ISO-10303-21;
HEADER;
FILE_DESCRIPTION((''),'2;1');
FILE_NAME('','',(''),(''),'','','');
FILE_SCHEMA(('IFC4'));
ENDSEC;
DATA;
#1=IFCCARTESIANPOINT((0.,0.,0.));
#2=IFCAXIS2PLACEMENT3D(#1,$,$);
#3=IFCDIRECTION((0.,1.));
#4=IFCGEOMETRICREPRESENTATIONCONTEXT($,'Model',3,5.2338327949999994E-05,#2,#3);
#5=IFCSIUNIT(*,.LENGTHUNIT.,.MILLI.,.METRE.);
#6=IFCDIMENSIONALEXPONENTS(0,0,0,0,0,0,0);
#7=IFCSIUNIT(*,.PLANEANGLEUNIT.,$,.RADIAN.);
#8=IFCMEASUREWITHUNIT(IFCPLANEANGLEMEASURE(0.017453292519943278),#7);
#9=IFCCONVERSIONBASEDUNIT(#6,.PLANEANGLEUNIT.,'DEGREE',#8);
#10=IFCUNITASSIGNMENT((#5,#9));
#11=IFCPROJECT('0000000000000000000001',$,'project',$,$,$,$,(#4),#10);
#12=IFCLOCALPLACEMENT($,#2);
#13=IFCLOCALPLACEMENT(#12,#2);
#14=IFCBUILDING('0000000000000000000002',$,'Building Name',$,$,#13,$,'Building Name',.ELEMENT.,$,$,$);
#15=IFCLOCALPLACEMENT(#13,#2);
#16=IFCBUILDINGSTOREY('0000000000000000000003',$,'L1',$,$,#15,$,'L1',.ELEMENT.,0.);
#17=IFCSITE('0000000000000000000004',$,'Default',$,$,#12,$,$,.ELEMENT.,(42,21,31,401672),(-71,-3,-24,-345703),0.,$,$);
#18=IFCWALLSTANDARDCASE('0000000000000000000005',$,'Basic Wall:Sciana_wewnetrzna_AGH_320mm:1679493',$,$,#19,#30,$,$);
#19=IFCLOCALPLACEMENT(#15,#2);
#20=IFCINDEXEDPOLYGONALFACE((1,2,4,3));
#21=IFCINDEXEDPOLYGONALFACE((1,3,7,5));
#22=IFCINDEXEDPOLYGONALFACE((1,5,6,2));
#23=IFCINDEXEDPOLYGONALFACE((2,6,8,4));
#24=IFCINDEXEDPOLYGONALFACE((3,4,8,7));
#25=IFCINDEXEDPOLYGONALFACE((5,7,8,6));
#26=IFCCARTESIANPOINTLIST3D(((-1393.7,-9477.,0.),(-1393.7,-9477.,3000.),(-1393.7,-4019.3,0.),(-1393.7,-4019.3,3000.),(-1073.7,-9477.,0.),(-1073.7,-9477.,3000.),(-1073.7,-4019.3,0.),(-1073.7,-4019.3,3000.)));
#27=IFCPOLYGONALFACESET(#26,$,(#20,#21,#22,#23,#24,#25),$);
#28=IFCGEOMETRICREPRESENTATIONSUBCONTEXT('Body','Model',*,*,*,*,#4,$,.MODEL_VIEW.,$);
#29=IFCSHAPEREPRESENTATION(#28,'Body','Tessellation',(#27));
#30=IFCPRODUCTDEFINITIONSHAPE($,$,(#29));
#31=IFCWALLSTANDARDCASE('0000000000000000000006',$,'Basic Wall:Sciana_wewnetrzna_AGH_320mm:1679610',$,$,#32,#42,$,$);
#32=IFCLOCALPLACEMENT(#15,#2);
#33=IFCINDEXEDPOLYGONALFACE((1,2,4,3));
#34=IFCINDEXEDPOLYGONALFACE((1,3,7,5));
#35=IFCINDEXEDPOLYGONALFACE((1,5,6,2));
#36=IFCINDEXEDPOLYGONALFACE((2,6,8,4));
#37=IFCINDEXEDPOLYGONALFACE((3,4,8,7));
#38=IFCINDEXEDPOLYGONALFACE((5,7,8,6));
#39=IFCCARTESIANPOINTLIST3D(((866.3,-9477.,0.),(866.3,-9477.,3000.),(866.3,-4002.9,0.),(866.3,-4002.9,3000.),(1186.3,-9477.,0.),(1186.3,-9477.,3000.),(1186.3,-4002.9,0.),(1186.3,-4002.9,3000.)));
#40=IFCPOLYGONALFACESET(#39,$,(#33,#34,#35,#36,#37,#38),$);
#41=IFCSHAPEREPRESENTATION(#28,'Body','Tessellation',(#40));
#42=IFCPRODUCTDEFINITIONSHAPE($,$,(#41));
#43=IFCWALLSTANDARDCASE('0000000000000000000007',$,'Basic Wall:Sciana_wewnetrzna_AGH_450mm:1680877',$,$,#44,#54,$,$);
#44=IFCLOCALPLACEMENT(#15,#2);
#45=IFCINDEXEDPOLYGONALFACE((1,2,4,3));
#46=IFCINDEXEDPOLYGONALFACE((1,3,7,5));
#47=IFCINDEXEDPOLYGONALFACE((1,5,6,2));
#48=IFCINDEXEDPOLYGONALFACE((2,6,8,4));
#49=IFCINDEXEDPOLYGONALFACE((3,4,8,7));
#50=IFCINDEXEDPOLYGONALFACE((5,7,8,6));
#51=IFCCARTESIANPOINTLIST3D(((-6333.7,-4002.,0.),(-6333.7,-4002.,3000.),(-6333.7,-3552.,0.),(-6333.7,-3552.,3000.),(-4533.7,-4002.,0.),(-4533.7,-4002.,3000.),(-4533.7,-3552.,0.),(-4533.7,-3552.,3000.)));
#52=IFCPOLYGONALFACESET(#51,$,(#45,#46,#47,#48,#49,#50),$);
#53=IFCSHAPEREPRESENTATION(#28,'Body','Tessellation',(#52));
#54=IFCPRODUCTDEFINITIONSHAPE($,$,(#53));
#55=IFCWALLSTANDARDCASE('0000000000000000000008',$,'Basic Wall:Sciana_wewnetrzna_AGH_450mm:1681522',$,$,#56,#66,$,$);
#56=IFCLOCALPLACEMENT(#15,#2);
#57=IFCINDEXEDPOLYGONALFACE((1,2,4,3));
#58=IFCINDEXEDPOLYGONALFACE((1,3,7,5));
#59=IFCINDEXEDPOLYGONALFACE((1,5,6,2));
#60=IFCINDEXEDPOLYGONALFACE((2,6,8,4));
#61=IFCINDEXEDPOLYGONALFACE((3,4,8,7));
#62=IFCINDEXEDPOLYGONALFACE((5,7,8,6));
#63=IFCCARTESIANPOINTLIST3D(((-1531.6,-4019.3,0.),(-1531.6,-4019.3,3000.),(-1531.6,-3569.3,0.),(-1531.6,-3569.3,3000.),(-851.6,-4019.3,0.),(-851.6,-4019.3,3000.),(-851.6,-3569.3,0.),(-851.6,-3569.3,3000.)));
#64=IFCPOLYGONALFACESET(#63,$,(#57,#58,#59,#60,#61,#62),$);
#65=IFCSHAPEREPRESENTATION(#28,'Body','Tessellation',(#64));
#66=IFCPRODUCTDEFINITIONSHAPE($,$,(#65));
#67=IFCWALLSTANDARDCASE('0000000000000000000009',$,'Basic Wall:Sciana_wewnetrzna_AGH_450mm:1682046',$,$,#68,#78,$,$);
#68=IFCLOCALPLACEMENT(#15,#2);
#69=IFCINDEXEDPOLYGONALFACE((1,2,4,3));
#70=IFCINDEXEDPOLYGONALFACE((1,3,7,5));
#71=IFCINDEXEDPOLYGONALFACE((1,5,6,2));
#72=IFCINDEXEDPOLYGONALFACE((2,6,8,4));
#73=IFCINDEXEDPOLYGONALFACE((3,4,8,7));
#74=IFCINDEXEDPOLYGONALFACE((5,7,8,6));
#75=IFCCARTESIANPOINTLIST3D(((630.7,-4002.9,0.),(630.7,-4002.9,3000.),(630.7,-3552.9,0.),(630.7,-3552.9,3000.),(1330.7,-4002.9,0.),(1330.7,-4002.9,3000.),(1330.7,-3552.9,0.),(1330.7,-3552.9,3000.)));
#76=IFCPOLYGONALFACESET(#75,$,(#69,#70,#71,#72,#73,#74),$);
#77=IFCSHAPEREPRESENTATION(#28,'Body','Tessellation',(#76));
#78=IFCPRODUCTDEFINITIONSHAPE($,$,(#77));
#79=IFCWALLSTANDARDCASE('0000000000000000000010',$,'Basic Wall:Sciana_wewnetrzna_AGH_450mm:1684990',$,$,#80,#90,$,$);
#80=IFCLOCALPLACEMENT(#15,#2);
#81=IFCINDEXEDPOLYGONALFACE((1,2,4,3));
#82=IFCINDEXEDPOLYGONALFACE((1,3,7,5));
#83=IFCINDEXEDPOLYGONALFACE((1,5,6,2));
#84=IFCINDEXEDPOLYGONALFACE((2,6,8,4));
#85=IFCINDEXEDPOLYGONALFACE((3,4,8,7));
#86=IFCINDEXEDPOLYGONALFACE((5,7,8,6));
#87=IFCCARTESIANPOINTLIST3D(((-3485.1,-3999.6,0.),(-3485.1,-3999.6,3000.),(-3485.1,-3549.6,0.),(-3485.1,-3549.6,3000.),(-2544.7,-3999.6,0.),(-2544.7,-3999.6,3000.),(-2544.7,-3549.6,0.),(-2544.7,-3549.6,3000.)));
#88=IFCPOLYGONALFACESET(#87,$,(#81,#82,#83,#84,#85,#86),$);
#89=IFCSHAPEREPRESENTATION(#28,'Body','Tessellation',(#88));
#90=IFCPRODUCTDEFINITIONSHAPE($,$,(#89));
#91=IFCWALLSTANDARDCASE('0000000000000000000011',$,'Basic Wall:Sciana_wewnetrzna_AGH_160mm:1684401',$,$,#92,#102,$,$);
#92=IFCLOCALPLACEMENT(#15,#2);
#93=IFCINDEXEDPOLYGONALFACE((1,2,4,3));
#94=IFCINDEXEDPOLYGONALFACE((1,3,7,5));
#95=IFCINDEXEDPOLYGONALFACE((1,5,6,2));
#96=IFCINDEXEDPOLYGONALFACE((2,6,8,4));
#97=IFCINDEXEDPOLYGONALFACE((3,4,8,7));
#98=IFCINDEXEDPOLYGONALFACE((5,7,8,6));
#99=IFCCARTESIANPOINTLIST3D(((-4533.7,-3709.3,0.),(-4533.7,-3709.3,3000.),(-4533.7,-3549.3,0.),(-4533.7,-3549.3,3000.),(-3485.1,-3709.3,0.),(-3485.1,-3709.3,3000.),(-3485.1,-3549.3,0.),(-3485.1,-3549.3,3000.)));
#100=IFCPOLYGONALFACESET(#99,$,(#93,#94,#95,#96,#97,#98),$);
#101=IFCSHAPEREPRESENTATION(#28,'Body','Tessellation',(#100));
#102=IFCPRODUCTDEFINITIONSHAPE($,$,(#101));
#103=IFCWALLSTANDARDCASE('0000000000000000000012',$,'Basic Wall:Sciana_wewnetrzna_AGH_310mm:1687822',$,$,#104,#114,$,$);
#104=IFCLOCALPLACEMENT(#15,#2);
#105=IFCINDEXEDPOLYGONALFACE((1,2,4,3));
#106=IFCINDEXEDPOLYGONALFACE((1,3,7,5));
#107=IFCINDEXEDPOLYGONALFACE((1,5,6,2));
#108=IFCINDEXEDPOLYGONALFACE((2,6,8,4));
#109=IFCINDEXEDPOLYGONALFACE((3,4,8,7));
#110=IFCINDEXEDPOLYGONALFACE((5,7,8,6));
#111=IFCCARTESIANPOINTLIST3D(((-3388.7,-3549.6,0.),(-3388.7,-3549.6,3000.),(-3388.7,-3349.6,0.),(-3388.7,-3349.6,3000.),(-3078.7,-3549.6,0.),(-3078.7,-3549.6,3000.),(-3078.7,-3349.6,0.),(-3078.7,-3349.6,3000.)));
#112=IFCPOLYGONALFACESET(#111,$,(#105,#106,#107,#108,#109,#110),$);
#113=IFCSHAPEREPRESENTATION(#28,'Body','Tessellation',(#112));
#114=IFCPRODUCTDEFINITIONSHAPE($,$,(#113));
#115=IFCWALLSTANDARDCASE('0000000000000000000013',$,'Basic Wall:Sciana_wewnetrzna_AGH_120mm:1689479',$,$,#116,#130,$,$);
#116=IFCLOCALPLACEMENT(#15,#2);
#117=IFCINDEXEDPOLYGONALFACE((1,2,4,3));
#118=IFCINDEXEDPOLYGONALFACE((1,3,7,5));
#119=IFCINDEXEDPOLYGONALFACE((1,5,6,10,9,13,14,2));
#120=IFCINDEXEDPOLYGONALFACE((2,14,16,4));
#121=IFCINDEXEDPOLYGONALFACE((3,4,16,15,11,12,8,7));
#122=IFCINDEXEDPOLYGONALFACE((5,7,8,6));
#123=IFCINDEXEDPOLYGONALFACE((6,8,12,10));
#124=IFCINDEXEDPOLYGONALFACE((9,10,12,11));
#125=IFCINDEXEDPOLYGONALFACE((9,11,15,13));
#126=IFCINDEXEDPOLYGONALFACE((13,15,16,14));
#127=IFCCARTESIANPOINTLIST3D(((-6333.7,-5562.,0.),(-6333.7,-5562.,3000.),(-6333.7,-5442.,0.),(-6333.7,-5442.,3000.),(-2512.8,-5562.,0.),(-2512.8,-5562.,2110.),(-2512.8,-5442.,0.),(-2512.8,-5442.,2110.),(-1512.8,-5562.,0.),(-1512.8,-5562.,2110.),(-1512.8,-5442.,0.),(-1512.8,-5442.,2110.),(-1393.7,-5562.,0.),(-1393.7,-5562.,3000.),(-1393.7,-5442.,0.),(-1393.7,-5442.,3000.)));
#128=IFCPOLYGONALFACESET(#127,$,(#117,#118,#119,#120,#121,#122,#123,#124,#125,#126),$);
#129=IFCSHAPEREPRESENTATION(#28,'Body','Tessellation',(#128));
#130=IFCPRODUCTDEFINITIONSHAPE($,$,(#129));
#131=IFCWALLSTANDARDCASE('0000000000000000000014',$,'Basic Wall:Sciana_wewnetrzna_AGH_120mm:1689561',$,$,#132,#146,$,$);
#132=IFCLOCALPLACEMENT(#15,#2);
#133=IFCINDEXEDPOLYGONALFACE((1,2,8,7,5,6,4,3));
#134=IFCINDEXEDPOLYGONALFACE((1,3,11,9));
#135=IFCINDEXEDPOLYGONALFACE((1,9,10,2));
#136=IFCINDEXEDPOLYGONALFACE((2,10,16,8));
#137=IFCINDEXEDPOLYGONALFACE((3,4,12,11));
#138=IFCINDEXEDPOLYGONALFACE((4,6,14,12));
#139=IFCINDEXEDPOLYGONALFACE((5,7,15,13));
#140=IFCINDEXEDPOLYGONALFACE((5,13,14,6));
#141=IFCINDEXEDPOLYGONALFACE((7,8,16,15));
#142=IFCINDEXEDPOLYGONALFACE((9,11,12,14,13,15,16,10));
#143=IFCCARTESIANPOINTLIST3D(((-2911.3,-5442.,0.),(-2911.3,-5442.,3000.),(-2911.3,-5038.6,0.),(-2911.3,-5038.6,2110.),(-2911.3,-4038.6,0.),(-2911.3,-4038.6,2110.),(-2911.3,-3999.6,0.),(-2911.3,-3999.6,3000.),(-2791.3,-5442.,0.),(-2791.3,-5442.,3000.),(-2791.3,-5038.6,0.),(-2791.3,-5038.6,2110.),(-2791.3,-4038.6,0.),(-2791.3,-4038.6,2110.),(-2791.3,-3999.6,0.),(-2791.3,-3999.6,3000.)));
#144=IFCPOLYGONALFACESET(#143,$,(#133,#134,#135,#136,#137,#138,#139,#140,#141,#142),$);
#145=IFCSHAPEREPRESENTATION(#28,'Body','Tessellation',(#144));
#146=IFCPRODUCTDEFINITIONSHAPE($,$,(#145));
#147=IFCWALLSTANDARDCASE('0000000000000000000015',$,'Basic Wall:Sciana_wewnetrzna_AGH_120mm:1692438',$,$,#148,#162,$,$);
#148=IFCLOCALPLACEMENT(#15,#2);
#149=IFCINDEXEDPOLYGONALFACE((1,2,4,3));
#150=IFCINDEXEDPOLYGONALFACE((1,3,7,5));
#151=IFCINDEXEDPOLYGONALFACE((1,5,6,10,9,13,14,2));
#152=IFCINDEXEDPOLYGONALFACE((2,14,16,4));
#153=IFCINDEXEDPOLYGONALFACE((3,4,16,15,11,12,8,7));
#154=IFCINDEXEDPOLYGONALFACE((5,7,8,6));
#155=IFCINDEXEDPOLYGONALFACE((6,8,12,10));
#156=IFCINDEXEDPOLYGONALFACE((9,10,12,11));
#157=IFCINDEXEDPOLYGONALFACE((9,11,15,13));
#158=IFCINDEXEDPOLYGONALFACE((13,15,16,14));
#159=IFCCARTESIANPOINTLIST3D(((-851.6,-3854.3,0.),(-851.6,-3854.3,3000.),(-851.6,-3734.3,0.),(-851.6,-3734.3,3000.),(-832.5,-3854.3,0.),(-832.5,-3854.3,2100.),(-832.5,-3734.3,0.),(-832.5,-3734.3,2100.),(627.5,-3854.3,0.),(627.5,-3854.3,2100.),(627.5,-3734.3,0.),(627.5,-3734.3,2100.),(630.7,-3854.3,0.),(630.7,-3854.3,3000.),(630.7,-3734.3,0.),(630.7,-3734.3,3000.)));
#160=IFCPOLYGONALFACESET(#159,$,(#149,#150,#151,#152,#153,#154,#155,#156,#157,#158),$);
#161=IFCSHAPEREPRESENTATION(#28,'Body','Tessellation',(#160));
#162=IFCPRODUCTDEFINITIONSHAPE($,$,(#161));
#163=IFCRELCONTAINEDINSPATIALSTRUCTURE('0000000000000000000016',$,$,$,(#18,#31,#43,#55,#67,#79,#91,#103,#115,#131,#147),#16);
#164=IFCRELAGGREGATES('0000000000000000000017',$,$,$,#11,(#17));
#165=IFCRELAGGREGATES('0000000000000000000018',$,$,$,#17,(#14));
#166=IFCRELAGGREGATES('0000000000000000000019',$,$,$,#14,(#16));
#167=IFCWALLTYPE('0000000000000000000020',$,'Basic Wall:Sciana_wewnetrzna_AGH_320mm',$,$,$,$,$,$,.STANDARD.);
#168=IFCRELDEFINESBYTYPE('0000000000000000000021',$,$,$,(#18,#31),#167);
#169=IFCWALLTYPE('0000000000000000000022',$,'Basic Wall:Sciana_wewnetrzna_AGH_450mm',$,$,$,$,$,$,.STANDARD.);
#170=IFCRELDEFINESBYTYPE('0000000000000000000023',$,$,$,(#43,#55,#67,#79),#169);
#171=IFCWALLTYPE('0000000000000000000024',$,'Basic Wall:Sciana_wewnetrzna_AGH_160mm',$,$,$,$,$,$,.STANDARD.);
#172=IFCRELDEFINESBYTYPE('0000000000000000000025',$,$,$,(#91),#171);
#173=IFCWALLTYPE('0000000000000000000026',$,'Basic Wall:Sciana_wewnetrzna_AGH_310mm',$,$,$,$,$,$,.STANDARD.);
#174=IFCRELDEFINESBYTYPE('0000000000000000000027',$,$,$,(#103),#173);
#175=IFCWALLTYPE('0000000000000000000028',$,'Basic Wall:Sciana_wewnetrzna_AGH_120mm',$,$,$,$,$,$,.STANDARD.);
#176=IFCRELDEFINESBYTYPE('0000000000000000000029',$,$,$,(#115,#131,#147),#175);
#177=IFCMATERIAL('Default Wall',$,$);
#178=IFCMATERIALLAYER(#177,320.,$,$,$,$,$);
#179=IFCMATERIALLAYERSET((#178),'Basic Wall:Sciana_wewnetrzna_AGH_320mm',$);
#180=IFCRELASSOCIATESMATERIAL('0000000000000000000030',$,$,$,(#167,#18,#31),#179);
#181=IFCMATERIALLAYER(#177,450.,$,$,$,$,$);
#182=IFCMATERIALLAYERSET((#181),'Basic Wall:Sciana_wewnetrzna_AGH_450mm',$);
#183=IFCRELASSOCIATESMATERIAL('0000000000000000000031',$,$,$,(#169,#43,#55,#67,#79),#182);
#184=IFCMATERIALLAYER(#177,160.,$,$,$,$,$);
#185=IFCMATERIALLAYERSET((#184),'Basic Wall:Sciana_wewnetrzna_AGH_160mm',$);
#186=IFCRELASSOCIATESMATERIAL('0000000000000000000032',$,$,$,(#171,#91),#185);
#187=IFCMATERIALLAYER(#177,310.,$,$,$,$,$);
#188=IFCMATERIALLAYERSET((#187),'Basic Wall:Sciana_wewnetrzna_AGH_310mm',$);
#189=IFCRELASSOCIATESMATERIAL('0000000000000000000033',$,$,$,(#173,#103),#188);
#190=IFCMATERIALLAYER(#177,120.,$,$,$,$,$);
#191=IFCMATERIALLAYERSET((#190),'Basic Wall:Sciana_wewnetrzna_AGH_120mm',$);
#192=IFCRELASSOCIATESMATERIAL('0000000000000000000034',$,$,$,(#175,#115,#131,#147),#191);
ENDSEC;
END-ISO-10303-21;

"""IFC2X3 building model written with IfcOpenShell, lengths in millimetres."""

from ifc_helpers import new_model, entity, si_unit, converted_unit, direction, frame, frame_2d, origin, place, context, subcontext, project, spatial, rectangle, extrude, material, layer, layer_set, layer_usage, type_object, element, save


model = new_model("IFC2X3")

# Units and contexts
model_context = context("Model", 3, precision=5.2338327949999994e-05, world=origin(), true_north=direction((0.0, 1.0)))
body_context = subcontext(model_context, "Body", "Model", "MODEL_VIEW")
ifc_project = project(units=[si_unit("LENGTHUNIT", "METRE", prefix="MILLI"), converted_unit("PLANEANGLEUNIT", "DEGREE", entity("IfcPlaneAngleMeasure", 0.017453292519943278), si_unit("PLANEANGLEUNIT", "RADIAN"), dimensions=[0, 0, 0, 0, 0, 0, 0])], contexts=[model_context])

# Site, building, storey
site_placement = place(None, origin())
site = spatial("IfcSite", under=ifc_project, at=site_placement, Name="Default", CompositionType="ELEMENT", RefLatitude=(42, 21, 31, 401672), RefLongitude=(-71, -3, -24, -345703), RefElevation=0.0)
building_placement = place(site_placement, origin())
building = spatial("IfcBuilding", under=site, at=building_placement, Name="Building Name", LongName="Building Name", CompositionType="ELEMENT")
storey_placement = place(building_placement, origin())
storey = spatial("IfcBuildingStorey", under=building, at=storey_placement, Name="L1", LongName="L1", CompositionType="ELEMENT", Elevation=0.0)

# Walls
ifc_material_1 = material(Name="Default Wall")
ifc_layer_1 = layer(ifc_material_1, 320.0)
ifc_layer_set_1 = layer_set([ifc_layer_1], Name="Basic Wall:Sciana_wewnetrzna_AGH_320mm")
ifc_layer_usage_1 = layer_usage(ifc_layer_set_1, "AXIS2", "NEGATIVE", 160.0)
wall_type_1 = type_object("IfcWallType", Name="Basic Wall:Sciana_wewnetrzna_AGH_320mm", PredefinedType="STANDARD", material=ifc_layer_set_1)
wall_1_placement = place(storey_placement, frame((-1233.7, -9477.0, 0.0), z_axis=(0.0, 0.0, 1.0), x_axis=(0.0, 1.0, 0.0)))
element("IfcWallStandardCase", 1, at=wall_1_placement, inside=storey, type_object=wall_type_1, material=ifc_layer_usage_1, Name="Basic Wall:Sciana_wewnetrzna_AGH_320mm:1679493", context=body_context, shape_type="SweptSolid", body=[
    extrude(rectangle(XDim=5457.6, YDim=320.0, at=frame_2d((2728.8, 0.0), x_axis=(-1.0, 0.0))), origin(), (0.0, 0.0, 1.0), 3000.0),
])
ifc_layer_usage_2 = layer_usage(ifc_layer_set_1, "AXIS2", "NEGATIVE", 160.0)
wall_2_placement = place(storey_placement, frame((1026.3, -9477.0, 0.0), z_axis=(0.0, 0.0, 1.0), x_axis=(0.0, 1.0, 0.0)))
element("IfcWallStandardCase", 2, at=wall_2_placement, inside=storey, type_object=wall_type_1, material=ifc_layer_usage_2, Name="Basic Wall:Sciana_wewnetrzna_AGH_320mm:1679610", context=body_context, shape_type="SweptSolid", body=[
    extrude(rectangle(XDim=5474.1, YDim=320.0, at=frame_2d((2737.0, 0.0), x_axis=(-1.0, 0.0))), origin(), (0.0, 0.0, 1.0), 3000.0),
])
ifc_layer_2 = layer(ifc_material_1, 450.0)
ifc_layer_set_2 = layer_set([ifc_layer_2], Name="Basic Wall:Sciana_wewnetrzna_AGH_450mm")
ifc_layer_usage_3 = layer_usage(ifc_layer_set_2, "AXIS2", "NEGATIVE", 225.0)
wall_type_2 = type_object("IfcWallType", Name="Basic Wall:Sciana_wewnetrzna_AGH_450mm", PredefinedType="STANDARD", material=ifc_layer_set_2)
wall_3_placement = place(storey_placement, frame((-6333.7, -3777.0, 0.0)))
element("IfcWallStandardCase", 3, at=wall_3_placement, inside=storey, type_object=wall_type_2, material=ifc_layer_usage_3, Name="Basic Wall:Sciana_wewnetrzna_AGH_450mm:1680877", context=body_context, shape_type="SweptSolid", body=[
    extrude(rectangle(XDim=1800.0, YDim=450.0, at=frame_2d((900.0, 0.0), x_axis=(-1.0, 0.0))), origin(), (0.0, 0.0, 1.0), 3000.0),
])
ifc_layer_usage_4 = layer_usage(ifc_layer_set_2, "AXIS2", "NEGATIVE", 225.0)
wall_4_placement = place(storey_placement, frame((-1531.6, -3794.3, 0.0)))
element("IfcWallStandardCase", 4, at=wall_4_placement, inside=storey, type_object=wall_type_2, material=ifc_layer_usage_4, Name="Basic Wall:Sciana_wewnetrzna_AGH_450mm:1681522", context=body_context, shape_type="SweptSolid", body=[
    extrude(rectangle(XDim=680.0, YDim=450.0, at=frame_2d((340.0, 0.0), x_axis=(-1.0, 0.0))), origin(), (0.0, 0.0, 1.0), 3000.0),
])
ifc_layer_usage_5 = layer_usage(ifc_layer_set_2, "AXIS2", "NEGATIVE", 225.0)
wall_5_placement = place(storey_placement, frame((630.7, -3777.9, 0.0)))
element("IfcWallStandardCase", 5, at=wall_5_placement, inside=storey, type_object=wall_type_2, material=ifc_layer_usage_5, Name="Basic Wall:Sciana_wewnetrzna_AGH_450mm:1682046", context=body_context, shape_type="SweptSolid", body=[
    extrude(rectangle(XDim=700.0, YDim=450.0, at=frame_2d((350.0, 0.0), x_axis=(-1.0, 0.0))), origin(), (0.0, 0.0, 1.0), 3000.0),
])
ifc_layer_usage_6 = layer_usage(ifc_layer_set_2, "AXIS2", "NEGATIVE", 225.0)
wall_6_placement = place(storey_placement, frame((-2544.7, -3774.6, 0.0), z_axis=(0.0, 0.0, 1.0), x_axis=(-1.0, 0.0, 0.0)))
element("IfcWallStandardCase", 6, at=wall_6_placement, inside=storey, type_object=wall_type_2, material=ifc_layer_usage_6, Name="Basic Wall:Sciana_wewnetrzna_AGH_450mm:1684990", context=body_context, shape_type="SweptSolid", body=[
    extrude(rectangle(XDim=940.4, YDim=450.0, at=frame_2d((470.2, 0.0), x_axis=(-1.0, 0.0))), origin(), (0.0, 0.0, 1.0), 3000.0),
])
ifc_layer_3 = layer(ifc_material_1, 160.0)
ifc_layer_set_3 = layer_set([ifc_layer_3], Name="Basic Wall:Sciana_wewnetrzna_AGH_160mm")
ifc_layer_usage_7 = layer_usage(ifc_layer_set_3, "AXIS2", "NEGATIVE", 80.0)
wall_type_3 = type_object("IfcWallType", Name="Basic Wall:Sciana_wewnetrzna_AGH_160mm", PredefinedType="STANDARD", material=ifc_layer_set_3)
wall_7_placement = place(storey_placement, frame((-4533.7, -3629.3, 0.0)))
element("IfcWallStandardCase", 7, at=wall_7_placement, inside=storey, type_object=wall_type_3, material=ifc_layer_usage_7, Name="Basic Wall:Sciana_wewnetrzna_AGH_160mm:1684401", context=body_context, shape_type="SweptSolid", body=[
    extrude(rectangle(XDim=1048.6, YDim=160.0, at=frame_2d((524.3, 0.0), x_axis=(-1.0, 0.0))), origin(), (0.0, 0.0, 1.0), 3000.0),
])
ifc_layer_4 = layer(ifc_material_1, 310.0)
ifc_layer_set_4 = layer_set([ifc_layer_4], Name="Basic Wall:Sciana_wewnetrzna_AGH_310mm")
ifc_layer_usage_8 = layer_usage(ifc_layer_set_4, "AXIS2", "NEGATIVE", 155.0)
wall_type_4 = type_object("IfcWallType", Name="Basic Wall:Sciana_wewnetrzna_AGH_310mm", PredefinedType="STANDARD", material=ifc_layer_set_4)
wall_8_placement = place(storey_placement, frame((-3233.7, -3549.6, 0.0), z_axis=(0.0, 0.0, 1.0), x_axis=(0.0, 1.0, 0.0)))
element("IfcWallStandardCase", 8, at=wall_8_placement, inside=storey, type_object=wall_type_4, material=ifc_layer_usage_8, Name="Basic Wall:Sciana_wewnetrzna_AGH_310mm:1687822", context=body_context, shape_type="SweptSolid", body=[
    extrude(rectangle(XDim=200.0, YDim=310.0, at=frame_2d((100.0, 0.0), x_axis=(-1.0, 0.0))), origin(), (0.0, 0.0, 1.0), 3000.0),
])

# Walls, openings
ifc_layer_5 = layer(ifc_material_1, 120.0)
ifc_layer_set_5 = layer_set([ifc_layer_5], Name="Basic Wall:Sciana_wewnetrzna_AGH_120mm")
ifc_layer_usage_9 = layer_usage(ifc_layer_set_5, "AXIS2", "NEGATIVE", 60.0)
wall_type_5 = type_object("IfcWallType", Name="Basic Wall:Sciana_wewnetrzna_AGH_120mm", PredefinedType="STANDARD", material=ifc_layer_set_5)
wall_9_placement = place(storey_placement, frame((-6333.7, -5502.0, 0.0)))
wall_9 = element("IfcWallStandardCase", 9, at=wall_9_placement, inside=storey, type_object=wall_type_5, material=ifc_layer_usage_9, Name="Basic Wall:Sciana_wewnetrzna_AGH_120mm:1689479", context=body_context, shape_type="SweptSolid", body=[
    extrude(rectangle(XDim=4940.0, YDim=120.0, at=frame_2d((2470.0, 0.0), x_axis=(-1.0, 0.0))), origin(), (0.0, 0.0, 1.0), 3000.0),
])
opening_1_placement = place(wall_9_placement, frame((3820.9, -60.0, 0.0)))
element("IfcOpeningElement", 10, at=opening_1_placement, cuts=wall_9, ObjectType="Opening", context=body_context, shape_type="SweptSolid", body=[
    extrude(rectangle(XDim=2110.0, YDim=1000.0, at=frame_2d((1055.0, 500.0), x_axis=(1.0, 0.0))), frame((0.0, 0.0, 0.0), z_axis=(0.0, 1.0, 0.0), x_axis=(0.0, 0.0, 1.0)), (0.0, 0.0, 1.0), 120.0),
])
ifc_layer_usage_10 = layer_usage(ifc_layer_set_5, "AXIS2", "NEGATIVE", 60.0)
wall_10_placement = place(storey_placement, frame((-2851.3, -3999.6, 0.0), z_axis=(0.0, 0.0, 1.0), x_axis=(0.0, -1.0, 0.0)))
wall_10 = element("IfcWallStandardCase", 11, at=wall_10_placement, inside=storey, type_object=wall_type_5, material=ifc_layer_usage_10, Name="Basic Wall:Sciana_wewnetrzna_AGH_120mm:1689561", context=body_context, shape_type="SweptSolid", body=[
    extrude(rectangle(XDim=1442.4, YDim=120.0, at=frame_2d((721.2, 0.0), x_axis=(1.0, 0.0))), origin(), (0.0, 0.0, 1.0), 3000.0),
])
opening_2_placement = place(wall_10_placement, frame((1039.1, 60.0, 0.0)))
element("IfcOpeningElement", 12, at=opening_2_placement, cuts=wall_10, ObjectType="Opening", context=body_context, shape_type="SweptSolid", body=[
    extrude(rectangle(XDim=2110.0, YDim=1000.0, at=frame_2d((1055.0, 500.0), x_axis=(1.0, 0.0))), frame((0.0, 0.0, 0.0), z_axis=(0.0, -1.0, 0.0), x_axis=(0.0, 0.0, 1.0)), (0.0, 0.0, 1.0), 120.0),
])
ifc_layer_usage_11 = layer_usage(ifc_layer_set_5, "AXIS2", "NEGATIVE", 60.0)
wall_11_placement = place(storey_placement, frame((-851.6, -3794.3, 0.0)))
wall_11 = element("IfcWallStandardCase", 13, at=wall_11_placement, inside=storey, type_object=wall_type_5, material=ifc_layer_usage_11, Name="Basic Wall:Sciana_wewnetrzna_AGH_120mm:1692438", context=body_context, shape_type="SweptSolid", body=[
    extrude(rectangle(XDim=1482.3, YDim=120.0, at=frame_2d((741.1, 0.0), x_axis=(1.0, 0.0))), origin(), (0.0, 0.0, 1.0), 3000.0),
])
opening_3_placement = place(wall_11_placement, frame((1479.1, 60.0, 0.0)))
element("IfcOpeningElement", 14, at=opening_3_placement, cuts=wall_11, ObjectType="Opening", context=body_context, shape_type="SweptSolid", body=[
    extrude(rectangle(XDim=2100.0, YDim=1460.0, at=frame_2d((1050.0, 730.0), x_axis=(1.0, 0.0))), frame((0.0, 0.0, 0.0), z_axis=(0.0, -1.0, 0.0), x_axis=(0.0, 0.0, 1.0)), (0.0, 0.0, 1.0), 120.0),
])

save(model, "model.ifc")
